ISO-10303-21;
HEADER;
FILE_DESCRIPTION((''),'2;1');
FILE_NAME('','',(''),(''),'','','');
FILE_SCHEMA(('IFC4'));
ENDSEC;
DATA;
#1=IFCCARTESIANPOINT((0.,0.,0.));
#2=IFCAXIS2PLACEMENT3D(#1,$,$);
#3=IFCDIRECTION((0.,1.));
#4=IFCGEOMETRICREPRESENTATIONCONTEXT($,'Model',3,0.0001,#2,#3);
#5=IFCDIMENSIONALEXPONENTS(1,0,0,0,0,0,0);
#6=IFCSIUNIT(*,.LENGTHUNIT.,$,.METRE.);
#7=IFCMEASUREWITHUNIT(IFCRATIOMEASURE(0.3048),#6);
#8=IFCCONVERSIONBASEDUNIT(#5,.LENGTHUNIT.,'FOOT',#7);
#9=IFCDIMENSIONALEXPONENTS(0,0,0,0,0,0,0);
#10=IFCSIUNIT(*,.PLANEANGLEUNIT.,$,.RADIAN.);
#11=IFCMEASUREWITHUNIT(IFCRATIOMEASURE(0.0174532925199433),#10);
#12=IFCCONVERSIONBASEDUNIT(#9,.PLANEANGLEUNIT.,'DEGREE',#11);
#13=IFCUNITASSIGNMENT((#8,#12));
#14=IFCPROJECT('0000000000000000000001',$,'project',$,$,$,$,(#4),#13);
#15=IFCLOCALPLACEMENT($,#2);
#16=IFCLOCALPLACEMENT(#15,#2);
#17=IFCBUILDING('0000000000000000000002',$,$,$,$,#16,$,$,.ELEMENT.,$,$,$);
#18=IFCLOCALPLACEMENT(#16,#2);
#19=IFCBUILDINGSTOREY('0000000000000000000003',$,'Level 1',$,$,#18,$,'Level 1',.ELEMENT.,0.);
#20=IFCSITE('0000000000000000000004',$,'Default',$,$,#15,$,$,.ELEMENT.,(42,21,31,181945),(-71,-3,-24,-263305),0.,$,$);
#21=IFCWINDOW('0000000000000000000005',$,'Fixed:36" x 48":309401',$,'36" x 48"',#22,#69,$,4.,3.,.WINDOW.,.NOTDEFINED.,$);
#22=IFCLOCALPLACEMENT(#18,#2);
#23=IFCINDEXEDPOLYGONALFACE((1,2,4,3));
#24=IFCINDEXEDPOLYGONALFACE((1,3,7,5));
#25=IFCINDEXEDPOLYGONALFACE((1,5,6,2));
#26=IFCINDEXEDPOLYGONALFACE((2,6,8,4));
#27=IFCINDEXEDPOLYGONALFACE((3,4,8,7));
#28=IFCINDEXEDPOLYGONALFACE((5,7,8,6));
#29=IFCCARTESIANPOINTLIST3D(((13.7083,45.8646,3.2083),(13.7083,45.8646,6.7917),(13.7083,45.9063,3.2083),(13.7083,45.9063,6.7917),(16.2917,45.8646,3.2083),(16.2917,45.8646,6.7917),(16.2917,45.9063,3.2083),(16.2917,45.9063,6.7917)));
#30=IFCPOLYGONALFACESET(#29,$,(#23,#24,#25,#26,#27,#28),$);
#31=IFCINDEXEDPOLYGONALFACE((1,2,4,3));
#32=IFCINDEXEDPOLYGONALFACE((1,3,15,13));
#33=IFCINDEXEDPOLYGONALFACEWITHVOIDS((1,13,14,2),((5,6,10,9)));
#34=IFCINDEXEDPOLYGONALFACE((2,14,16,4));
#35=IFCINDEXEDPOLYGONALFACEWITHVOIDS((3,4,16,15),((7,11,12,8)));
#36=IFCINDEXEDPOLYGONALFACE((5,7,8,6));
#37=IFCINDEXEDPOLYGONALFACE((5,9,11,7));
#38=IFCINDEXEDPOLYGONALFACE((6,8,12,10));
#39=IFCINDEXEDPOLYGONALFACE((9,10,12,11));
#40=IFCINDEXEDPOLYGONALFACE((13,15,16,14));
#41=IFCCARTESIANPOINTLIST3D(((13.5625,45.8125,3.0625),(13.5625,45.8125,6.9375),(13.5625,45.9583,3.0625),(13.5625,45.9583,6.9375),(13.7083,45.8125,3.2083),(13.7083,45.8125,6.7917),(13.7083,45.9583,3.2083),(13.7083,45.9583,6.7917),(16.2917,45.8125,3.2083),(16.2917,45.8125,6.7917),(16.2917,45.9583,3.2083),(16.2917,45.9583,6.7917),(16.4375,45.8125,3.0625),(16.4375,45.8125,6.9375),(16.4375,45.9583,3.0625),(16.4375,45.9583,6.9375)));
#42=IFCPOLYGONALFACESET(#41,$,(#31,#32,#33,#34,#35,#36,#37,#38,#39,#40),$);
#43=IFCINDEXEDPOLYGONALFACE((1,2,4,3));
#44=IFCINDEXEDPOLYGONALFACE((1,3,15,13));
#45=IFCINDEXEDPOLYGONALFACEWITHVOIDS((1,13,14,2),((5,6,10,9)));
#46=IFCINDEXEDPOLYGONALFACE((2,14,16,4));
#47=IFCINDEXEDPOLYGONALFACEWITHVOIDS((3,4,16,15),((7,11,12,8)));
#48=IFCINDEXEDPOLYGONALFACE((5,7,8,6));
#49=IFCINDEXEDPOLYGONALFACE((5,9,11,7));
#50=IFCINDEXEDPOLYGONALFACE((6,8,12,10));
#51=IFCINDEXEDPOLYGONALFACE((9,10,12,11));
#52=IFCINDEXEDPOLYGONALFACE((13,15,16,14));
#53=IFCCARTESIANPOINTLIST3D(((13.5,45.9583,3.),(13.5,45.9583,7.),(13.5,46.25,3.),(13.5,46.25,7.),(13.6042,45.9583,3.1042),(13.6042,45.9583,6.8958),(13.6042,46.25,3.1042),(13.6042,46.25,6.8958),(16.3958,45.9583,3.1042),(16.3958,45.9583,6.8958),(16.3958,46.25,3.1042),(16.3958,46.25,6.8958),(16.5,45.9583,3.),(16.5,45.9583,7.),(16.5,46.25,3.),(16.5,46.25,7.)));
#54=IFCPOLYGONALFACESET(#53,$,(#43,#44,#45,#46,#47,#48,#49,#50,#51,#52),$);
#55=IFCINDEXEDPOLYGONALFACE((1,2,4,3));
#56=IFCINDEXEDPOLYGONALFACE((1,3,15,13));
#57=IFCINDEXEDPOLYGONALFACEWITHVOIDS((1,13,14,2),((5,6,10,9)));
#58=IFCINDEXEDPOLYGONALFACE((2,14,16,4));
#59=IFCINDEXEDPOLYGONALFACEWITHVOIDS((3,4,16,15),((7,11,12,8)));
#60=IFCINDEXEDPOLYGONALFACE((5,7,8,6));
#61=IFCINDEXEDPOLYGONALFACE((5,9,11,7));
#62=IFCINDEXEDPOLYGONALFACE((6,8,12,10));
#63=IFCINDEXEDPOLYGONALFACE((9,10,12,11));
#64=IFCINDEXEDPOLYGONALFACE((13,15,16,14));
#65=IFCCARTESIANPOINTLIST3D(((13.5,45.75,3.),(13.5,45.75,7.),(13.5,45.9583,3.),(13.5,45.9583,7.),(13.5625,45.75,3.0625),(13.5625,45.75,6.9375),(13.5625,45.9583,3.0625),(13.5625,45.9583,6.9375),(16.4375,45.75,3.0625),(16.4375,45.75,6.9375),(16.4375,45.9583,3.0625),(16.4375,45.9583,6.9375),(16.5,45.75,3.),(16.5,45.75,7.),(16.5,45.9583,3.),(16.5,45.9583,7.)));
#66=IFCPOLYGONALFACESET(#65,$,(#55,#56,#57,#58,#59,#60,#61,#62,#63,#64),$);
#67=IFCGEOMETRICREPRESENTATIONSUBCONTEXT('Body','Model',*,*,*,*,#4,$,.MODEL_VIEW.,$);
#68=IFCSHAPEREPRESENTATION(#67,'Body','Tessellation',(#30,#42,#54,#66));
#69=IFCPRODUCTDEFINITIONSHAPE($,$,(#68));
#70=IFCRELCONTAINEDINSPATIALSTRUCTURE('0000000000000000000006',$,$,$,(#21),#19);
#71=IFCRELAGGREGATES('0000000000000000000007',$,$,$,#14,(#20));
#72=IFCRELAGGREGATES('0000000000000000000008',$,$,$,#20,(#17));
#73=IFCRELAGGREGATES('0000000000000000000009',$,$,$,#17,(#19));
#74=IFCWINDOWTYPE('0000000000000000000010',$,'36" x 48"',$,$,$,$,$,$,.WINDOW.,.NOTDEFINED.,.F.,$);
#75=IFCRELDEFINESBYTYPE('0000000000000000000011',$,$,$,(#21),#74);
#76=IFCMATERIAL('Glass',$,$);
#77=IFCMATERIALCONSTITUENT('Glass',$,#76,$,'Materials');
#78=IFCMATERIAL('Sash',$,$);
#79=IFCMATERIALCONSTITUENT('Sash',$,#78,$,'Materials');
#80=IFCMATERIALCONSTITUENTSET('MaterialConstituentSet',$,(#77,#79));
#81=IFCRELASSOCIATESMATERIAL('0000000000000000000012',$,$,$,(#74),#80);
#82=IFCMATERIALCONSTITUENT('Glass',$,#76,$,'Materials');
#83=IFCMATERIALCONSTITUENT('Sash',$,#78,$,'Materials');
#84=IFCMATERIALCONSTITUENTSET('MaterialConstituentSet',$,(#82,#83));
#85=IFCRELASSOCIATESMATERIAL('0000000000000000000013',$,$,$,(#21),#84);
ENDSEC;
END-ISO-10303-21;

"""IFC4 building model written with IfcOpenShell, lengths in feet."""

from ifc_helpers import new_model, entity, si_unit, converted_unit, direction, frame, frame_2d, origin, place, context, subcontext, project, spatial, polyline, rectangle, outline, extrude, source, transform, mapped, material, constituent, constituent_set, type_object, type_shapes, element, save


model = new_model("IFC4")

# Units and contexts
model_context = context("Model", 3, precision=0.0001, world=origin(), true_north=direction((0.0, 1.0)))
body_context = subcontext(model_context, "Body", "Model", "MODEL_VIEW")
ifc_project = project(units=[converted_unit("LENGTHUNIT", "FOOT", entity("IfcRatioMeasure", 0.3048), si_unit("LENGTHUNIT", "METRE"), dimensions=[1, 0, 0, 0, 0, 0, 0]), converted_unit("PLANEANGLEUNIT", "DEGREE", entity("IfcRatioMeasure", 0.0174532925199433), si_unit("PLANEANGLEUNIT", "RADIAN"), dimensions=[0, 0, 0, 0, 0, 0, 0])], contexts=[model_context])

# Site, building, storey
site_placement = place(None, origin())
site = spatial("IfcSite", under=ifc_project, at=site_placement, Name="Default", CompositionType="ELEMENT", RefLatitude=(42, 21, 31, 181945), RefLongitude=(-71, -3, -24, -263305), RefElevation=0.0)
building_placement = place(site_placement, origin())
building = spatial("IfcBuilding", under=site, at=building_placement, CompositionType="ELEMENT")
storey_placement = place(building_placement, origin())
storey = spatial("IfcBuildingStorey", under=building, at=storey_placement, Name="Level 1", LongName="Level 1", CompositionType="ELEMENT", Elevation=0.0)

# Shared definitions
placement_1 = place(storey_placement, frame((-0.25, 46.0, 0.0)))

# Window
ifc_material_1 = material(Name="Glass")
ifc_constituent_1 = constituent(ifc_material_1, Name="Glass", Category="Materials")
ifc_material_2 = material(Name="Sash")
ifc_constituent_2 = constituent(ifc_material_2, Name="Sash", Category="Materials")
ifc_constituent_set_1 = constituent_set(constituents=[ifc_constituent_1, ifc_constituent_2], Name="MaterialConstituentSet")
ifc_constituent_3 = constituent(ifc_material_1, Name="Glass", Category="Materials")
ifc_constituent_4 = constituent(ifc_material_2, Name="Sash", Category="Materials")
ifc_constituent_set_2 = constituent_set(constituents=[ifc_constituent_3, ifc_constituent_4], Name="MaterialConstituentSet")
window_type = type_object("IfcWindowType", Name="36\" x 48\"", ParameterTakesPrecedence=False, PartitioningType="NOTDEFINED", PredefinedType="WINDOW", material=ifc_constituent_set_2)
shared_shape = source(origin(), body_context, "Body", "SweptSolid", [
    extrude(rectangle(XDim=0.0417, YDim=2.5833, at=frame_2d((0.0, 0.0), x_axis=(1.0, 0.0))), frame((1.5, 0.3646, 0.2083), z_axis=(0.0, 0.0, 1.0), x_axis=(0.0, 1.0, 0.0)), (0.0, 0.0, 1.0), 3.5833),
    extrude(outline(polyline([(-1.4375, -1.9375), (1.4375, -1.9375), (1.4375, 1.9375), (-1.4375, 1.9375), (-1.4375, -1.9375)]), holes=[polyline([(-1.2917, -1.7917), (-1.2917, 1.7917), (1.2917, 1.7917), (1.2917, -1.7917), (-1.2917, -1.7917)])]), frame((1.5, 0.2917, 2.0), z_axis=(0.0, 1.0, 0.0), x_axis=(1.0, 0.0, 0.0)), (0.0, 0.0, 1.0), 0.1458),
    extrude(outline(polyline([(-1.5, -2.0), (1.5, -2.0), (1.5, 2.0), (-1.5, 2.0), (-1.5, -2.0)]), holes=[polyline([(-1.3958, -1.8958), (-1.3958, 1.8958), (1.3958, 1.8958), (1.3958, -1.8958), (-1.3958, -1.8958)])]), frame((1.5, 0.0, 2.0), z_axis=(0.0, 1.0, 0.0), x_axis=(1.0, 0.0, 0.0)), (0.0, 0.0, 1.0), 0.2917),
    extrude(outline(polyline([(-2.0, -1.5), (2.0, -1.5), (2.0, 1.5), (-2.0, 1.5), (-2.0, -1.5)]), holes=[polyline([(-1.9375, -1.4375), (-1.9375, 1.4375), (1.9375, 1.4375), (1.9375, -1.4375), (-1.9375, -1.4375)])]), frame((1.5, 0.2917, 2.0), z_axis=(0.0, 1.0, 0.0), x_axis=(0.0, 0.0, -1.0)), (0.0, 0.0, 1.0), 0.2083),
])
type_shapes(window_type, [shared_shape])
placement_2 = place(placement_1, frame((16.75, 0.25, 3.0)))
window_placement = place(placement_2, frame((0.0, 0.0, 0.0), z_axis=(0.0, 0.0, 1.0), x_axis=(-1.0, 0.0, 0.0)))
element("IfcWindow", 1, at=window_placement, inside=storey, type_object=window_type, material=ifc_constituent_set_1, Name="Fixed:36\" x 48\":309401", ObjectType="36\" x 48\"", OverallHeight=4.0, OverallWidth=3.0, PartitioningType="NOTDEFINED", PredefinedType="WINDOW", context=body_context, shape_type="MappedRepresentation", body=[
    mapped(shared_shape, transform((0.0, 0.0, 0.0), scale=1.0)),
])

save(model, "model.ifc")
